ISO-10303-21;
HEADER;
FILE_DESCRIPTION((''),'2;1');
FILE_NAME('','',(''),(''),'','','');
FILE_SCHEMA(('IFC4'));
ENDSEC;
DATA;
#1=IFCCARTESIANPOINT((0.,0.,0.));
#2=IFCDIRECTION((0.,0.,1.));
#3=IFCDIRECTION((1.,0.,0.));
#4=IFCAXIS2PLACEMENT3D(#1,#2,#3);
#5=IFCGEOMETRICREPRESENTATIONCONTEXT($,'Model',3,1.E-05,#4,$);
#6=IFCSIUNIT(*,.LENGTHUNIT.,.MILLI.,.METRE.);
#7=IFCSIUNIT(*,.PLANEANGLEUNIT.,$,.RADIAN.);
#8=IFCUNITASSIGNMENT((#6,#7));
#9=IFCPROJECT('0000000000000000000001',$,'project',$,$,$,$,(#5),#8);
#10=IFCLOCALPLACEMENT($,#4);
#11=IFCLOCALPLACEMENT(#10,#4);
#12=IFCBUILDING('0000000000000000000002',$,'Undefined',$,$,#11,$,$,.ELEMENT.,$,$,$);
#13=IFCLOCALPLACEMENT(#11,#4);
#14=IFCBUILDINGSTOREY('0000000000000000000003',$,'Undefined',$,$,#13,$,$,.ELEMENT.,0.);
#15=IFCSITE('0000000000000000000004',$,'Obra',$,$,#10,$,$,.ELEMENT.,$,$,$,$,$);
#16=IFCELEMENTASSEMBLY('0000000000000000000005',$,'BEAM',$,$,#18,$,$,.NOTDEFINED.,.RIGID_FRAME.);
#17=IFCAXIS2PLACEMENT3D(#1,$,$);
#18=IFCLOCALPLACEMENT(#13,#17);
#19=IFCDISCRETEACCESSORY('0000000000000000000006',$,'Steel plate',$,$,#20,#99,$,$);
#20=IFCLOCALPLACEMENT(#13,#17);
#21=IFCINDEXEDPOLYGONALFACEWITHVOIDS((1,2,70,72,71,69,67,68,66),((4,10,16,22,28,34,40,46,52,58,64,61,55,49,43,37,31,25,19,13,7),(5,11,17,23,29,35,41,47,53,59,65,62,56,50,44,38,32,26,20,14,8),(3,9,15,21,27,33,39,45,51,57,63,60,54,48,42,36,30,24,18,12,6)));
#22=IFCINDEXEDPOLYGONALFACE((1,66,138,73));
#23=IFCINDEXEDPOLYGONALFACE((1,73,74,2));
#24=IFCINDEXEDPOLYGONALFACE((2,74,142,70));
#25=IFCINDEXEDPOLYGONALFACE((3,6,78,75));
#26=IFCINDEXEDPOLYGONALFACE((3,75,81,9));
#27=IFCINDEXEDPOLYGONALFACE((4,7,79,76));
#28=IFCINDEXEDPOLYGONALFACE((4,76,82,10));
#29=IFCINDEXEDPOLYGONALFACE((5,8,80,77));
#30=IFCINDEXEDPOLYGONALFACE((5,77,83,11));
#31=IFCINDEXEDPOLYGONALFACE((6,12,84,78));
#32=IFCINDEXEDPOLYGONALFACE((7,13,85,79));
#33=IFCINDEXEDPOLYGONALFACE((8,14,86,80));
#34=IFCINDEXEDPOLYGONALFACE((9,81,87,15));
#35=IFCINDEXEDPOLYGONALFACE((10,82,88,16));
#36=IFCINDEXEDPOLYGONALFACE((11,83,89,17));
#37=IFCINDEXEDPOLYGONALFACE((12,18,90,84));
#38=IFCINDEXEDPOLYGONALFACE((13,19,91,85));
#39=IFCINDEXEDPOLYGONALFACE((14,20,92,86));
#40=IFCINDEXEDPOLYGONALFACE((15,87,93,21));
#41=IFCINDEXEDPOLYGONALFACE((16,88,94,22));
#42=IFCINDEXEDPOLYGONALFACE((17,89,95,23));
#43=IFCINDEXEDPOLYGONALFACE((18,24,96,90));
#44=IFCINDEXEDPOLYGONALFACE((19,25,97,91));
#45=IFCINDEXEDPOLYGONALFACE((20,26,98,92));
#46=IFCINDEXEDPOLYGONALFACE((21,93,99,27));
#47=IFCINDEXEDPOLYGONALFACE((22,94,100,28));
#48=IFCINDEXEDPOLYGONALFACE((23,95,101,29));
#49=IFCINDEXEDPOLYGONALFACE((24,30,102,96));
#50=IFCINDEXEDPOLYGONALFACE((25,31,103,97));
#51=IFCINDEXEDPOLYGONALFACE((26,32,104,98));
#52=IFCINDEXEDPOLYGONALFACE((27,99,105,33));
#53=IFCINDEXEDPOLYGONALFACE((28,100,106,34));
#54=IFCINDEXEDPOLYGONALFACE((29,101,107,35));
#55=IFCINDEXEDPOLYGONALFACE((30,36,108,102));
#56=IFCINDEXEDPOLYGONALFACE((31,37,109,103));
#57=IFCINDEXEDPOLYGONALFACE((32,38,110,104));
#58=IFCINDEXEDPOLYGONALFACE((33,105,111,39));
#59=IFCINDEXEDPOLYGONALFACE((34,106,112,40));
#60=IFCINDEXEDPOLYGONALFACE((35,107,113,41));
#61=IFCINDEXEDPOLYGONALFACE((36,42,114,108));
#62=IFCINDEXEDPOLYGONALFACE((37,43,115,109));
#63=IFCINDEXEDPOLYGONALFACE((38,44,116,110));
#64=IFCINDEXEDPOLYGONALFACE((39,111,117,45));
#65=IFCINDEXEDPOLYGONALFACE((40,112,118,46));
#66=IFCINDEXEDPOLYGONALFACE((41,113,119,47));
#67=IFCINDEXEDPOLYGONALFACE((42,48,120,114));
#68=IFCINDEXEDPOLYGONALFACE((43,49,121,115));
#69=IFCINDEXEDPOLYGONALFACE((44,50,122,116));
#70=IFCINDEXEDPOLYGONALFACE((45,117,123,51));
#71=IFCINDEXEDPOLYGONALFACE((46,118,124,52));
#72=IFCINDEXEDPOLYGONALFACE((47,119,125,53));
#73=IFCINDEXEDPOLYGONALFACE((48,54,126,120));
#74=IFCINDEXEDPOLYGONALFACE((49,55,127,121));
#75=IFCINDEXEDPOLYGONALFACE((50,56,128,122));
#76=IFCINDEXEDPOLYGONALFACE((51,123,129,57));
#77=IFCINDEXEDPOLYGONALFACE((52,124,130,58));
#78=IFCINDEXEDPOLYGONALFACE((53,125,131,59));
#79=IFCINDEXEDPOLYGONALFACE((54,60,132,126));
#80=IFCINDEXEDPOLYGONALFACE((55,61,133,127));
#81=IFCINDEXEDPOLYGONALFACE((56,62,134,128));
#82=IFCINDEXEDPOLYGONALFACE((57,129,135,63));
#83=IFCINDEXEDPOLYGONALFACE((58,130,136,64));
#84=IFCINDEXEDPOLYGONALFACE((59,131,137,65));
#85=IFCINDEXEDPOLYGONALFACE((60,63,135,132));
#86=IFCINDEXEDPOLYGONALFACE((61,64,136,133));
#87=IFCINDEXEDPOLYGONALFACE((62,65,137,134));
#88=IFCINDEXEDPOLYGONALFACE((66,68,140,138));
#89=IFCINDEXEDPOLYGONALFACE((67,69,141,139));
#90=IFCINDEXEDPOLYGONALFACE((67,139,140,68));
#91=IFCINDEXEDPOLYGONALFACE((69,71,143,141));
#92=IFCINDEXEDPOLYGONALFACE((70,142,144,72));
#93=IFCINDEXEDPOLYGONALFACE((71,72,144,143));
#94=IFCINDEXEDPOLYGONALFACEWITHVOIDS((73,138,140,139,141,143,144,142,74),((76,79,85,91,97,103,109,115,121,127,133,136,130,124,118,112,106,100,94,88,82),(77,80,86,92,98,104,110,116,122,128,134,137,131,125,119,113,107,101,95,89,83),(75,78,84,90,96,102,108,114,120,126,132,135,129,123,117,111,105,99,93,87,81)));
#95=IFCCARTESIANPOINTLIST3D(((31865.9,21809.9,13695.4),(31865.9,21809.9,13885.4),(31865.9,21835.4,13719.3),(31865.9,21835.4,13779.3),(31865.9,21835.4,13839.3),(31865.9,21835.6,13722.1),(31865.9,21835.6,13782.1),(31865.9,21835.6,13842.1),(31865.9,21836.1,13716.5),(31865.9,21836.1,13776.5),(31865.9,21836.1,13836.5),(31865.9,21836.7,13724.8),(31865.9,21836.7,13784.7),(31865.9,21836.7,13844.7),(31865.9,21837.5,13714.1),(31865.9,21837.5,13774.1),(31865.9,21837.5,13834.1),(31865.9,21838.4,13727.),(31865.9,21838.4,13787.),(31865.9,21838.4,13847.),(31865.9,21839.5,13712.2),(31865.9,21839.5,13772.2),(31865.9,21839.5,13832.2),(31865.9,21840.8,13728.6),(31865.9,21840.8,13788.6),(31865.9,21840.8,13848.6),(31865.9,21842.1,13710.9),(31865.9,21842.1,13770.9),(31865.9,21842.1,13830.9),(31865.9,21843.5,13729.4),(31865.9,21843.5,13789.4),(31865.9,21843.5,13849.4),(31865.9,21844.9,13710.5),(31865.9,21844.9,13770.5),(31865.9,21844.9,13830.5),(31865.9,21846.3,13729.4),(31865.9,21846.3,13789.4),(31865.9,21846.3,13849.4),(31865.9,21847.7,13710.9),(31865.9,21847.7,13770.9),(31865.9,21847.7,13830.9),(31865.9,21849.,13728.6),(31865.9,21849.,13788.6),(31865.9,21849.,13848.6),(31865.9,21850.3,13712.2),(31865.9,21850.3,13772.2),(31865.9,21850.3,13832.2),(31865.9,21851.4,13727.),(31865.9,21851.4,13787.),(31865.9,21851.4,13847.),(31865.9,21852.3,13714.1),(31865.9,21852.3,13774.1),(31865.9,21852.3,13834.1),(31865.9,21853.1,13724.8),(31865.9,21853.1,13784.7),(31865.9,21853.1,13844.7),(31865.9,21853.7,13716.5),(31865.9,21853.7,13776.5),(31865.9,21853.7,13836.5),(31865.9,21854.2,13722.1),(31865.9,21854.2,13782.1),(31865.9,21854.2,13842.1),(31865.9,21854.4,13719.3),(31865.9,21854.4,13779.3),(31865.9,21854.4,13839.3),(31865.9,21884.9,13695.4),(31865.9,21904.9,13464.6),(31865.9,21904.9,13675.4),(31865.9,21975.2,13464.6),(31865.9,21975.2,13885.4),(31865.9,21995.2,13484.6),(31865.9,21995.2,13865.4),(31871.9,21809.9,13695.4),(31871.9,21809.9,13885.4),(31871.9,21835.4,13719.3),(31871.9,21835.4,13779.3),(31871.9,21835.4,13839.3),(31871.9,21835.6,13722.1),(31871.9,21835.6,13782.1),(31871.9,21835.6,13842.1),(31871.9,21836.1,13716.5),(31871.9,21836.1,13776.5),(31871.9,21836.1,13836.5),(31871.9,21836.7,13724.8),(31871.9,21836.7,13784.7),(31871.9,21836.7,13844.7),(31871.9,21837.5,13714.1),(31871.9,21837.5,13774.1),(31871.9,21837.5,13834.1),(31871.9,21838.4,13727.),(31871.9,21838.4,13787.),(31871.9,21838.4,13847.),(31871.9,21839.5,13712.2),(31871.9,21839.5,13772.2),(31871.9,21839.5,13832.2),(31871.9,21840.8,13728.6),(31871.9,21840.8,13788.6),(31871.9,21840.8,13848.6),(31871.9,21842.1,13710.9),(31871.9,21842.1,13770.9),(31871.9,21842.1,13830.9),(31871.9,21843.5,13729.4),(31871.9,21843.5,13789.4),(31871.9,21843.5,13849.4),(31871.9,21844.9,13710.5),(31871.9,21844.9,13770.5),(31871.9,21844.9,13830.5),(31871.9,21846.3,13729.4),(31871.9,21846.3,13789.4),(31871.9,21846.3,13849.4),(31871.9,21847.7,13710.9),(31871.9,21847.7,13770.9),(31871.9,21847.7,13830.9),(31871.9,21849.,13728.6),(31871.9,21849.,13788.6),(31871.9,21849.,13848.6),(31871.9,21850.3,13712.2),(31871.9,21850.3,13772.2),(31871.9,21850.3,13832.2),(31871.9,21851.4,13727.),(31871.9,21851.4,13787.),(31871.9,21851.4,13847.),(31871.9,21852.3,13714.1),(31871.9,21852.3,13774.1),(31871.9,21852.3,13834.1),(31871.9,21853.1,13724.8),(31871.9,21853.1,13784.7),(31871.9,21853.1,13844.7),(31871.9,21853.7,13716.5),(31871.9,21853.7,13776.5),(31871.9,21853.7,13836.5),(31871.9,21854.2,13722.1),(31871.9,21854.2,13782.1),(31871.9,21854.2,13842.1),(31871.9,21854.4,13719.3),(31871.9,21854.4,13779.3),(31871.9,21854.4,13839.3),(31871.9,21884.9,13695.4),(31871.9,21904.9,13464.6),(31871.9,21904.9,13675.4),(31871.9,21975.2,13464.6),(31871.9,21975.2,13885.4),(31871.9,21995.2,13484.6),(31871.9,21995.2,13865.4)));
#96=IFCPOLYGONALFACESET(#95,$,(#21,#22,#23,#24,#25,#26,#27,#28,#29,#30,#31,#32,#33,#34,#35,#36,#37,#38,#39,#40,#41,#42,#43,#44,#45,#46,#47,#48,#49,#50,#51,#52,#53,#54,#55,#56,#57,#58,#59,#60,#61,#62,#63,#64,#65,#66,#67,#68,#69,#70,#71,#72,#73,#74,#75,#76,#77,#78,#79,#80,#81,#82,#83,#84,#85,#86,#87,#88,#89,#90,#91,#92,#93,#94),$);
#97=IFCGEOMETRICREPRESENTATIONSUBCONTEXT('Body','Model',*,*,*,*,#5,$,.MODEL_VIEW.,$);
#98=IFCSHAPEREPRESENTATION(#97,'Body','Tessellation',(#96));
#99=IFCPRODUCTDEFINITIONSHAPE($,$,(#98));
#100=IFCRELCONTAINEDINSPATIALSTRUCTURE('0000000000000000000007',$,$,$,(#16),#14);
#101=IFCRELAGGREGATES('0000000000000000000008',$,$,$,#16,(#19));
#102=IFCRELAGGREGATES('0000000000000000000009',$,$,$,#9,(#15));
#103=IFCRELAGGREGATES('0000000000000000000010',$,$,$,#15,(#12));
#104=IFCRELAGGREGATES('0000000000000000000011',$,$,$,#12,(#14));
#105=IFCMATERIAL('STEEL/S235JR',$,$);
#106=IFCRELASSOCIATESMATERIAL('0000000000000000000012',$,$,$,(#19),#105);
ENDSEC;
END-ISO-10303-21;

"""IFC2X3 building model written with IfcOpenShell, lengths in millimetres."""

from ifc_helpers import new_model, si_unit, frame, origin_with_axes, origin_2d_with_axis, place, context, subcontext, project, spatial, polyline, circle, outline, extrude, source, transform, mapped, material, element, aggregate, save


model = new_model("IFC2X3")

# Units and contexts
model_context = context("Model", 3, precision=1e-05, world=origin_with_axes())
body_context = subcontext(model_context, "Body", "Model", "MODEL_VIEW")
ifc_project = project(units=[si_unit("LENGTHUNIT", "METRE", prefix="MILLI"), si_unit("PLANEANGLEUNIT", "RADIAN")], contexts=[model_context])

# Site, building, storey
site_placement = place(None, origin_with_axes())
site = spatial("IfcSite", under=ifc_project, at=site_placement, Name="Obra", CompositionType="ELEMENT")
building_placement = place(site_placement, origin_with_axes())
building = spatial("IfcBuilding", under=site, at=building_placement, Name="Undefined", CompositionType="ELEMENT")
storey_placement = place(building_placement, origin_with_axes())
storey = spatial("IfcBuildingStorey", under=building, at=storey_placement, Name="Undefined", CompositionType="ELEMENT", Elevation=0.0)

# Shared definitions
ifc_material_1 = material(Name="STEEL/S235JR")

# Element assembly
assembly_1_placement = place(storey_placement, origin_with_axes())
assembly_1 = element("IfcElementAssembly", 1, at=assembly_1_placement, inside=storey, Name="BEAM", AssemblyPlace="NOTDEFINED", PredefinedType="RIGID_FRAME")

# Shared definitions
shared_shape_1 = source(origin_with_axes(), body_context, "Body", "SweptSolid", [
    extrude(circle(Radius=9.5, at=origin_2d_with_axis()), frame((0.0, -9.2, 0.0), z_axis=(0.0, 1.0, 0.0), x_axis=(1.0, 0.0, 0.0)), (0.0, 0.0, 1.0), 6.2),
])

# Discrete accessory, opening
discrete_accessory_1_placement = place(assembly_1_placement, frame((31868.9, 21995.2, 13484.6), z_axis=(-1.0, 0.0, 0.0), x_axis=(0.000001, -0.707107, -0.707107)))
discrete_accessory_1 = element("IfcDiscreteAccessory", 2, at=discrete_accessory_1_placement, material=ifc_material_1, Name="Steel plate", context=body_context, shape_type="SweptSolid", body=[
    extrude(outline(polyline([(0.0, 0.0), (28.3, 0.0), (78.0, 49.7), (-71.1, 198.8), (-71.1, 227.1), (-18.0, 280.1), (-152.4, 414.4), (-269.3, 297.6), (-269.3, 269.3), (0.0, 0.0)])), frame((0.0, 0.0, -3.0), z_axis=(0.0, 0.0, 1.0), x_axis=(1.0, 0.0, 0.0)), (0.0, 0.0, 1.0), 6.0),
])
opening_1_placement = place(assembly_1_placement, frame((31875.0, 21894.9, 13885.4), z_axis=(0.0, -1.0, 0.0), x_axis=(0.0, 0.0, -1.0)))
element("IfcOpeningElement", 3, at=opening_1_placement, cuts=discrete_accessory_1, ObjectType="Opening", context=body_context, shape_type="MappedRepresentation", body=[
    mapped(shared_shape_1, transform((165.4, 0.0, 50.0))),
    mapped(shared_shape_1, transform((105.4, 0.0, 50.0))),
    mapped(shared_shape_1, transform((45.4, 0.0, 50.0))),
])
aggregate(assembly_1, [discrete_accessory_1])

save(model, "model.ifc")
